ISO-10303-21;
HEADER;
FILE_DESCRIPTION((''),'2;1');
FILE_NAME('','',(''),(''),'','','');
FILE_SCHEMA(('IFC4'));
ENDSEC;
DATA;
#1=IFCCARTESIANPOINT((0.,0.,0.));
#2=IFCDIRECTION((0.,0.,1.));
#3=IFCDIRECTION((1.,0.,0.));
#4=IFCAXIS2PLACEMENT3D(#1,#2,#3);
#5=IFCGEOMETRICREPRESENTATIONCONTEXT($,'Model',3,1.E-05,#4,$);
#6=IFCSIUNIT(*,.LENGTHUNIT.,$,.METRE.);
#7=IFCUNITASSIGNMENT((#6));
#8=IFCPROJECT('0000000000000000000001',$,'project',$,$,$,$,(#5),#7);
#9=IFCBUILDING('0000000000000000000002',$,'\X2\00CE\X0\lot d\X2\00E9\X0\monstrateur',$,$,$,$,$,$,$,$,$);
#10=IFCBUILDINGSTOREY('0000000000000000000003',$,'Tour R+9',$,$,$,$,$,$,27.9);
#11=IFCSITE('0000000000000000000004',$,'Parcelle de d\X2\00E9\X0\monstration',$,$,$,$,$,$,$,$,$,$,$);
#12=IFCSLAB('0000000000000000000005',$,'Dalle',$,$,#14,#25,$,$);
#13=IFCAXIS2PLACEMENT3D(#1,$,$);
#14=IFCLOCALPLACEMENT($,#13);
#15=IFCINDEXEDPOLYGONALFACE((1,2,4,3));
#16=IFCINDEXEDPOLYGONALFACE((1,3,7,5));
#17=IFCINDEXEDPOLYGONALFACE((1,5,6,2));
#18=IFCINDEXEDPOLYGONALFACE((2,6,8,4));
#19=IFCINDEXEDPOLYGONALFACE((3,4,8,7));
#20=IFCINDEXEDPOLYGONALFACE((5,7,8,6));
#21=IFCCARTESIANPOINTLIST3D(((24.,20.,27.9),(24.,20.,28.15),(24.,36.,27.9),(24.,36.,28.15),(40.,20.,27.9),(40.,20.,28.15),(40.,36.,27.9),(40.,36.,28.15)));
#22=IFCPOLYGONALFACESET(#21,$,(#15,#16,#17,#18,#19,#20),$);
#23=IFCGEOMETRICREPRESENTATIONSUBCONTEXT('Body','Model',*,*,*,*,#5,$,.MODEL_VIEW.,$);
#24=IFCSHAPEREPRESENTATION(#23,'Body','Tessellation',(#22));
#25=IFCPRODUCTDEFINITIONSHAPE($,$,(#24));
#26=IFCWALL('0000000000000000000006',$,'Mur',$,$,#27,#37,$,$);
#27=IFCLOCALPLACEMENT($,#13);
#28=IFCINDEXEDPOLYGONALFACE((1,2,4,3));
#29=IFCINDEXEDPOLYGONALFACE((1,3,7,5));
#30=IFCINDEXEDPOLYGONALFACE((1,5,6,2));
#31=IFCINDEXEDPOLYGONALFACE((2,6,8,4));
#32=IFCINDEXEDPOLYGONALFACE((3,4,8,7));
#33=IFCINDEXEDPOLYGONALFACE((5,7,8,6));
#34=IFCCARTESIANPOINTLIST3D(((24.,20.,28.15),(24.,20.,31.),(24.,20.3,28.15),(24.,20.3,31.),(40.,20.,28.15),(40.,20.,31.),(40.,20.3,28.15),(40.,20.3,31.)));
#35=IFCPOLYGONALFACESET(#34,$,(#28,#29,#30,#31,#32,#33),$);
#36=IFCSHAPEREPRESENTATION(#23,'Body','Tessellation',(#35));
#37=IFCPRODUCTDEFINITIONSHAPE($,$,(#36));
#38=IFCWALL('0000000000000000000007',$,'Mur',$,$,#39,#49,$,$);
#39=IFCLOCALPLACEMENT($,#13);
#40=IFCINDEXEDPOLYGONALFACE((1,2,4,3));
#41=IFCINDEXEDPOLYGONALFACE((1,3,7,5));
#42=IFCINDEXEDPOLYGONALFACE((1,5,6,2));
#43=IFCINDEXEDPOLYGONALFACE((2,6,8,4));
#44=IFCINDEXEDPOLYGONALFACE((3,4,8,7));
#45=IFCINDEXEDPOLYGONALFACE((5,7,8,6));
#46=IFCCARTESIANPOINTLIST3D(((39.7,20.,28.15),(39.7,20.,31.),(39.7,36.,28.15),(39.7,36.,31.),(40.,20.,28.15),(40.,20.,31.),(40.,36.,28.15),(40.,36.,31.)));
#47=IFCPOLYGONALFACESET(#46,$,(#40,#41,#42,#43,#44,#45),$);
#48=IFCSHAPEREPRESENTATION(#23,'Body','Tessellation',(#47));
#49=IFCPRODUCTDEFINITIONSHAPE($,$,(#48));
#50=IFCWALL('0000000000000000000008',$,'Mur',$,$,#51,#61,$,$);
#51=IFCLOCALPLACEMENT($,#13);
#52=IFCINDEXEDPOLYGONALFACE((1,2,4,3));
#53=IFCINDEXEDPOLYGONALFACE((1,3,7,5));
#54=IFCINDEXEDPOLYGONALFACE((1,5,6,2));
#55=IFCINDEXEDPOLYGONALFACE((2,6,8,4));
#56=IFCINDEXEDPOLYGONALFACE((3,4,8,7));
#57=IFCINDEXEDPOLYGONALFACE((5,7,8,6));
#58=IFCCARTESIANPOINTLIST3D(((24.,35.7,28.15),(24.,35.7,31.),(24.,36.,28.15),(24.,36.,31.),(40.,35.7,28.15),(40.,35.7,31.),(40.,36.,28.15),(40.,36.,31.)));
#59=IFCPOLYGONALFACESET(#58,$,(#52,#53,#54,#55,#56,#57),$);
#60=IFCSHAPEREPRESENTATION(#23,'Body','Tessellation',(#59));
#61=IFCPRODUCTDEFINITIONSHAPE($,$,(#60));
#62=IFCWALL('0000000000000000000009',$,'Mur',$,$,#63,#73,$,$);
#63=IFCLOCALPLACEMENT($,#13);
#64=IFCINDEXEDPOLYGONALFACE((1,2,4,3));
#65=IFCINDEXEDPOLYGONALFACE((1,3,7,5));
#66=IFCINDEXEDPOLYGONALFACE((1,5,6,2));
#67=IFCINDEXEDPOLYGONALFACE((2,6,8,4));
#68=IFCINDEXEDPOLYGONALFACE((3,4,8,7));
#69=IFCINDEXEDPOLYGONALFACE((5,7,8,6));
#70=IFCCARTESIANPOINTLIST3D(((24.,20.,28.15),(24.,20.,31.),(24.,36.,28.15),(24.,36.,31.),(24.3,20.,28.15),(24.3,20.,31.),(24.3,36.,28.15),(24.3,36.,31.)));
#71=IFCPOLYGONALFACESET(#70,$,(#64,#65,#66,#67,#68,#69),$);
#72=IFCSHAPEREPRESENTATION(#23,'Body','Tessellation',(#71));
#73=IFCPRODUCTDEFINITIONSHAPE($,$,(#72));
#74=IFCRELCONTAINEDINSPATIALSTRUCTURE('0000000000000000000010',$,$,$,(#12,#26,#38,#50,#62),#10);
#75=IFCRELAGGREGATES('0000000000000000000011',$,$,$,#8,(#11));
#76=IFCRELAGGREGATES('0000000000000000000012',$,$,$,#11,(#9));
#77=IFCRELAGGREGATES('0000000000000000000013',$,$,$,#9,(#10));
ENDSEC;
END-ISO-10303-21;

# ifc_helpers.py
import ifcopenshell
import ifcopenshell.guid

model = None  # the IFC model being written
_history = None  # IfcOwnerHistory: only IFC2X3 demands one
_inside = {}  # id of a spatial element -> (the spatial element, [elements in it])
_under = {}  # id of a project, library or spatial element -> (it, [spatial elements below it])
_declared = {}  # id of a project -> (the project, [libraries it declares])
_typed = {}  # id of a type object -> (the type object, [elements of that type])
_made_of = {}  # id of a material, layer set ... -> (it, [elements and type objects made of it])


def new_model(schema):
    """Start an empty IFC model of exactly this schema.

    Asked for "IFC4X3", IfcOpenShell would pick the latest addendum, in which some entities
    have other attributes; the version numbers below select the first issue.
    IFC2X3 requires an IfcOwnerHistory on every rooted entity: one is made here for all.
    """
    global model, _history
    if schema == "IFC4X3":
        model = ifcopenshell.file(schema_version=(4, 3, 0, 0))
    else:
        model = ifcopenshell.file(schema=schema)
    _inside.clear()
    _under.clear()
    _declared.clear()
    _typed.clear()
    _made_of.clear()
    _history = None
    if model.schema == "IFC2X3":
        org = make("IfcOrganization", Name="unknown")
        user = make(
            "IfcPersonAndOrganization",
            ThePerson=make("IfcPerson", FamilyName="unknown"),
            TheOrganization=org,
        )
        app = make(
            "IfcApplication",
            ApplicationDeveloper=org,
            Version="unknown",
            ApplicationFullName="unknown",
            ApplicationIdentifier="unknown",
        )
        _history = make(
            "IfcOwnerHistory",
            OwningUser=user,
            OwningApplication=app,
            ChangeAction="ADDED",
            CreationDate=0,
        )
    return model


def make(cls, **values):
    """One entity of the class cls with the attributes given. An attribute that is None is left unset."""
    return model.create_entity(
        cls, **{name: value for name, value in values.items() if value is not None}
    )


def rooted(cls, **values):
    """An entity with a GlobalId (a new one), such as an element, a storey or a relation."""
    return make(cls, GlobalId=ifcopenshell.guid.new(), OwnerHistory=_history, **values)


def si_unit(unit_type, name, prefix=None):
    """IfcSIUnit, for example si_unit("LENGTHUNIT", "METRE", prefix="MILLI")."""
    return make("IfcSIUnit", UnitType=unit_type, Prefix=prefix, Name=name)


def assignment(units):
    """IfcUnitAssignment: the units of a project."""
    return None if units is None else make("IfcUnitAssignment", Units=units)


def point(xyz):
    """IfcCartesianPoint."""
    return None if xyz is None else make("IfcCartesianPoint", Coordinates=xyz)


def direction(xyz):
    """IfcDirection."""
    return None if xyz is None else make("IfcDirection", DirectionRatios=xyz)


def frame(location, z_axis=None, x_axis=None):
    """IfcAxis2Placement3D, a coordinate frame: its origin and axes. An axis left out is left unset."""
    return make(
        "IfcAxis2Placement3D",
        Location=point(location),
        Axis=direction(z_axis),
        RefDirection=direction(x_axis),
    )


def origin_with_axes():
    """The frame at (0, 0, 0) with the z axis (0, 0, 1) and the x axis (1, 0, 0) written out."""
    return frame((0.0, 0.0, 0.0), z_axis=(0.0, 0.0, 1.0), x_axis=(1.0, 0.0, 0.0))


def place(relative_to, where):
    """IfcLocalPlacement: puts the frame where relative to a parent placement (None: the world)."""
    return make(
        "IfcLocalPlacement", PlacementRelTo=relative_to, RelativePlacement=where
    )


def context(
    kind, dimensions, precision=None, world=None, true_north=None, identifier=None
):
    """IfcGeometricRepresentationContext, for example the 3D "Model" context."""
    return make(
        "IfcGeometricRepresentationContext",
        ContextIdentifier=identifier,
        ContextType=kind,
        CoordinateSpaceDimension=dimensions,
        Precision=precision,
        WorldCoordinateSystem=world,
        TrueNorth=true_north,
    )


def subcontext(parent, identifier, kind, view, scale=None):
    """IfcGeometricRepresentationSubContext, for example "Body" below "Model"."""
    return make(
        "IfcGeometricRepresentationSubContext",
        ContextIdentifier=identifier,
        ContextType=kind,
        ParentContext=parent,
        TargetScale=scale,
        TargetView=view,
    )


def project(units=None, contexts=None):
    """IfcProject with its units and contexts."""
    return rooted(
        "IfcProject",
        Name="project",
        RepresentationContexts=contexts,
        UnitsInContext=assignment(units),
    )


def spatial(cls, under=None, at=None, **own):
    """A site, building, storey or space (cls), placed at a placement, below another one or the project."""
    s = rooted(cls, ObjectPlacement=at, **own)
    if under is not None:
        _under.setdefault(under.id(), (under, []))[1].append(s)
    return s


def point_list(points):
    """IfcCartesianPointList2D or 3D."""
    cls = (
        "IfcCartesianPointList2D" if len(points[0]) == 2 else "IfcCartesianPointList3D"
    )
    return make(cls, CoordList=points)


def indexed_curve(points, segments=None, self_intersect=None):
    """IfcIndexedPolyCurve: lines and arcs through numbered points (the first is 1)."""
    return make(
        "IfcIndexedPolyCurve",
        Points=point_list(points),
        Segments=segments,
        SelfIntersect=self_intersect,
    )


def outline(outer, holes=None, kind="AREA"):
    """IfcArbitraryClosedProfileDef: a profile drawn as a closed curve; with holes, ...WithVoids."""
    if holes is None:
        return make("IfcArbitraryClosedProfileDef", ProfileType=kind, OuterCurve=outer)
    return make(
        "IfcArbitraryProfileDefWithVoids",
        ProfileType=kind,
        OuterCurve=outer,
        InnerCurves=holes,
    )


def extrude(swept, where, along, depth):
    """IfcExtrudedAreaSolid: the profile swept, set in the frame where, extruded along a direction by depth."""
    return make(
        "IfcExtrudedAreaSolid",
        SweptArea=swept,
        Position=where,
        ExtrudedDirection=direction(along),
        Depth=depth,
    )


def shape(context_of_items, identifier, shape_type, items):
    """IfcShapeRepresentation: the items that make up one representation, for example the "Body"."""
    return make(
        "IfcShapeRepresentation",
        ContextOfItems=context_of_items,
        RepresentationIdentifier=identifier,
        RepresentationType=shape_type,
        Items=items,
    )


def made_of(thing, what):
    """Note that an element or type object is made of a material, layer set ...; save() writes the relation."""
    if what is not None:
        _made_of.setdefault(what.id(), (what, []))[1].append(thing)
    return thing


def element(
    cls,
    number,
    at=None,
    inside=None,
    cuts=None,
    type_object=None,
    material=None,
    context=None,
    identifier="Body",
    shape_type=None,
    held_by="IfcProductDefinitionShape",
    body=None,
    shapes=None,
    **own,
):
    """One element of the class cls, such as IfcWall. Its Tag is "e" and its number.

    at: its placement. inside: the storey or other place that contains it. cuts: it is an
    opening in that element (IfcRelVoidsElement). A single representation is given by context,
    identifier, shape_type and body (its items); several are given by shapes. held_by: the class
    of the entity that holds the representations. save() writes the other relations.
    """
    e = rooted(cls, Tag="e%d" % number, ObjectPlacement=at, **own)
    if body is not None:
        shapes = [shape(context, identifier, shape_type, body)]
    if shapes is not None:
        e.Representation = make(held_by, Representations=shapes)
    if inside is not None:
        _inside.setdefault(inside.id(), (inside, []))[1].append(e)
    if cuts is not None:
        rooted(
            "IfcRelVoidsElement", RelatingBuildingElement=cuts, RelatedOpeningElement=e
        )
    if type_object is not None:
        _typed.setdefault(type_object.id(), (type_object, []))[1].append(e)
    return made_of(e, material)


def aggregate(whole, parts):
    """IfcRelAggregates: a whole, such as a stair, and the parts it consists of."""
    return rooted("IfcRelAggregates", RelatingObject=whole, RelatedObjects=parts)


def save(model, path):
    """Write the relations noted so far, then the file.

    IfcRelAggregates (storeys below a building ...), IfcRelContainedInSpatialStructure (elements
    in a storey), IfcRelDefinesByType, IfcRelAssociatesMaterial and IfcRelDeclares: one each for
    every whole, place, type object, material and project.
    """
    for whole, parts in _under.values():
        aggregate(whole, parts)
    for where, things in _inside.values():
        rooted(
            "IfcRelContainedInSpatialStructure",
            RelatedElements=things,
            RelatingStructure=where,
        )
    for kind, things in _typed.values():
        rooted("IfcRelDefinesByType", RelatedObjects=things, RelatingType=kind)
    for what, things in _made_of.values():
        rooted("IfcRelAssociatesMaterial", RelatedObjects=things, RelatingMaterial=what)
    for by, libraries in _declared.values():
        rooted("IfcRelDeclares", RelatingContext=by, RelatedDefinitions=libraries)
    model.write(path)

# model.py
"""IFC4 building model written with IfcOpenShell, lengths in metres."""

from ifc_helpers import new_model, si_unit, frame, origin_with_axes, place, context, subcontext, project, spatial, indexed_curve, outline, extrude, element, save


model = new_model("IFC4")

# Units and contexts
model_context = context("Model", 3, precision=1e-05, world=origin_with_axes())
body_context = subcontext(model_context, "Body", "Model", "MODEL_VIEW")
ifc_project = project(units=[si_unit("LENGTHUNIT", "METRE")], contexts=[model_context])

# Site, building, storey
site = spatial("IfcSite", under=ifc_project, Name="Parcelle de démonstration")
building = spatial("IfcBuilding", under=site, Name="Îlot démonstrateur")
storey = spatial("IfcBuildingStorey", under=building, Name="Tour R+9", Elevation=27.9)

# Slab
slab_placement = place(None, frame((0.0, 0.0, 27.9), z_axis=(0.0, 0.0, 1.0), x_axis=(1.0, 0.0, 0.0)))
element("IfcSlab", 1, at=slab_placement, inside=storey, Name="Dalle", context=body_context, shape_type="SweptSolid", body=[
    extrude(outline(indexed_curve([(24.0, 20.0), (40.0, 20.0), (40.0, 36.0), (24.0, 36.0)])), None, (0.0, 0.0, 1.0), 0.25),
])

# Walls
for number, where, z_axis, x_axis, name in (
    (2, (24.0, 20.0, 28.15), (0.0, 0.0, 1.0), (1.0, 0.0, 0.0), "Mur"),
    (3, (40.0, 20.0, 28.15), (0.0, 0.0, 1.0), (0.0, 1.0, 0.0), "Mur"),
    (4, (40.0, 36.0, 28.15), (0.0, 0.0, 1.0), (-1.0, 0.0, 0.0), "Mur"),
    (5, (24.0, 36.0, 28.15), (0.0, 0.0, 1.0), (0.0, -1.0, 0.0), "Mur"),
):
    element("IfcWall", number, at=place(None, frame(where, z_axis=z_axis, x_axis=x_axis)), inside=storey, Name=name, context=body_context, shape_type="SweptSolid", body=[
        extrude(outline(indexed_curve([(0.0, 0.0), (0.0, 0.3), (16.0, 0.3), (16.0, 0.0), (0.0, 0.0)], self_intersect=False)), origin_with_axes(), (0.0, 0.0, 1.0), 2.85),
    ])

save(model, "model.ifc")
